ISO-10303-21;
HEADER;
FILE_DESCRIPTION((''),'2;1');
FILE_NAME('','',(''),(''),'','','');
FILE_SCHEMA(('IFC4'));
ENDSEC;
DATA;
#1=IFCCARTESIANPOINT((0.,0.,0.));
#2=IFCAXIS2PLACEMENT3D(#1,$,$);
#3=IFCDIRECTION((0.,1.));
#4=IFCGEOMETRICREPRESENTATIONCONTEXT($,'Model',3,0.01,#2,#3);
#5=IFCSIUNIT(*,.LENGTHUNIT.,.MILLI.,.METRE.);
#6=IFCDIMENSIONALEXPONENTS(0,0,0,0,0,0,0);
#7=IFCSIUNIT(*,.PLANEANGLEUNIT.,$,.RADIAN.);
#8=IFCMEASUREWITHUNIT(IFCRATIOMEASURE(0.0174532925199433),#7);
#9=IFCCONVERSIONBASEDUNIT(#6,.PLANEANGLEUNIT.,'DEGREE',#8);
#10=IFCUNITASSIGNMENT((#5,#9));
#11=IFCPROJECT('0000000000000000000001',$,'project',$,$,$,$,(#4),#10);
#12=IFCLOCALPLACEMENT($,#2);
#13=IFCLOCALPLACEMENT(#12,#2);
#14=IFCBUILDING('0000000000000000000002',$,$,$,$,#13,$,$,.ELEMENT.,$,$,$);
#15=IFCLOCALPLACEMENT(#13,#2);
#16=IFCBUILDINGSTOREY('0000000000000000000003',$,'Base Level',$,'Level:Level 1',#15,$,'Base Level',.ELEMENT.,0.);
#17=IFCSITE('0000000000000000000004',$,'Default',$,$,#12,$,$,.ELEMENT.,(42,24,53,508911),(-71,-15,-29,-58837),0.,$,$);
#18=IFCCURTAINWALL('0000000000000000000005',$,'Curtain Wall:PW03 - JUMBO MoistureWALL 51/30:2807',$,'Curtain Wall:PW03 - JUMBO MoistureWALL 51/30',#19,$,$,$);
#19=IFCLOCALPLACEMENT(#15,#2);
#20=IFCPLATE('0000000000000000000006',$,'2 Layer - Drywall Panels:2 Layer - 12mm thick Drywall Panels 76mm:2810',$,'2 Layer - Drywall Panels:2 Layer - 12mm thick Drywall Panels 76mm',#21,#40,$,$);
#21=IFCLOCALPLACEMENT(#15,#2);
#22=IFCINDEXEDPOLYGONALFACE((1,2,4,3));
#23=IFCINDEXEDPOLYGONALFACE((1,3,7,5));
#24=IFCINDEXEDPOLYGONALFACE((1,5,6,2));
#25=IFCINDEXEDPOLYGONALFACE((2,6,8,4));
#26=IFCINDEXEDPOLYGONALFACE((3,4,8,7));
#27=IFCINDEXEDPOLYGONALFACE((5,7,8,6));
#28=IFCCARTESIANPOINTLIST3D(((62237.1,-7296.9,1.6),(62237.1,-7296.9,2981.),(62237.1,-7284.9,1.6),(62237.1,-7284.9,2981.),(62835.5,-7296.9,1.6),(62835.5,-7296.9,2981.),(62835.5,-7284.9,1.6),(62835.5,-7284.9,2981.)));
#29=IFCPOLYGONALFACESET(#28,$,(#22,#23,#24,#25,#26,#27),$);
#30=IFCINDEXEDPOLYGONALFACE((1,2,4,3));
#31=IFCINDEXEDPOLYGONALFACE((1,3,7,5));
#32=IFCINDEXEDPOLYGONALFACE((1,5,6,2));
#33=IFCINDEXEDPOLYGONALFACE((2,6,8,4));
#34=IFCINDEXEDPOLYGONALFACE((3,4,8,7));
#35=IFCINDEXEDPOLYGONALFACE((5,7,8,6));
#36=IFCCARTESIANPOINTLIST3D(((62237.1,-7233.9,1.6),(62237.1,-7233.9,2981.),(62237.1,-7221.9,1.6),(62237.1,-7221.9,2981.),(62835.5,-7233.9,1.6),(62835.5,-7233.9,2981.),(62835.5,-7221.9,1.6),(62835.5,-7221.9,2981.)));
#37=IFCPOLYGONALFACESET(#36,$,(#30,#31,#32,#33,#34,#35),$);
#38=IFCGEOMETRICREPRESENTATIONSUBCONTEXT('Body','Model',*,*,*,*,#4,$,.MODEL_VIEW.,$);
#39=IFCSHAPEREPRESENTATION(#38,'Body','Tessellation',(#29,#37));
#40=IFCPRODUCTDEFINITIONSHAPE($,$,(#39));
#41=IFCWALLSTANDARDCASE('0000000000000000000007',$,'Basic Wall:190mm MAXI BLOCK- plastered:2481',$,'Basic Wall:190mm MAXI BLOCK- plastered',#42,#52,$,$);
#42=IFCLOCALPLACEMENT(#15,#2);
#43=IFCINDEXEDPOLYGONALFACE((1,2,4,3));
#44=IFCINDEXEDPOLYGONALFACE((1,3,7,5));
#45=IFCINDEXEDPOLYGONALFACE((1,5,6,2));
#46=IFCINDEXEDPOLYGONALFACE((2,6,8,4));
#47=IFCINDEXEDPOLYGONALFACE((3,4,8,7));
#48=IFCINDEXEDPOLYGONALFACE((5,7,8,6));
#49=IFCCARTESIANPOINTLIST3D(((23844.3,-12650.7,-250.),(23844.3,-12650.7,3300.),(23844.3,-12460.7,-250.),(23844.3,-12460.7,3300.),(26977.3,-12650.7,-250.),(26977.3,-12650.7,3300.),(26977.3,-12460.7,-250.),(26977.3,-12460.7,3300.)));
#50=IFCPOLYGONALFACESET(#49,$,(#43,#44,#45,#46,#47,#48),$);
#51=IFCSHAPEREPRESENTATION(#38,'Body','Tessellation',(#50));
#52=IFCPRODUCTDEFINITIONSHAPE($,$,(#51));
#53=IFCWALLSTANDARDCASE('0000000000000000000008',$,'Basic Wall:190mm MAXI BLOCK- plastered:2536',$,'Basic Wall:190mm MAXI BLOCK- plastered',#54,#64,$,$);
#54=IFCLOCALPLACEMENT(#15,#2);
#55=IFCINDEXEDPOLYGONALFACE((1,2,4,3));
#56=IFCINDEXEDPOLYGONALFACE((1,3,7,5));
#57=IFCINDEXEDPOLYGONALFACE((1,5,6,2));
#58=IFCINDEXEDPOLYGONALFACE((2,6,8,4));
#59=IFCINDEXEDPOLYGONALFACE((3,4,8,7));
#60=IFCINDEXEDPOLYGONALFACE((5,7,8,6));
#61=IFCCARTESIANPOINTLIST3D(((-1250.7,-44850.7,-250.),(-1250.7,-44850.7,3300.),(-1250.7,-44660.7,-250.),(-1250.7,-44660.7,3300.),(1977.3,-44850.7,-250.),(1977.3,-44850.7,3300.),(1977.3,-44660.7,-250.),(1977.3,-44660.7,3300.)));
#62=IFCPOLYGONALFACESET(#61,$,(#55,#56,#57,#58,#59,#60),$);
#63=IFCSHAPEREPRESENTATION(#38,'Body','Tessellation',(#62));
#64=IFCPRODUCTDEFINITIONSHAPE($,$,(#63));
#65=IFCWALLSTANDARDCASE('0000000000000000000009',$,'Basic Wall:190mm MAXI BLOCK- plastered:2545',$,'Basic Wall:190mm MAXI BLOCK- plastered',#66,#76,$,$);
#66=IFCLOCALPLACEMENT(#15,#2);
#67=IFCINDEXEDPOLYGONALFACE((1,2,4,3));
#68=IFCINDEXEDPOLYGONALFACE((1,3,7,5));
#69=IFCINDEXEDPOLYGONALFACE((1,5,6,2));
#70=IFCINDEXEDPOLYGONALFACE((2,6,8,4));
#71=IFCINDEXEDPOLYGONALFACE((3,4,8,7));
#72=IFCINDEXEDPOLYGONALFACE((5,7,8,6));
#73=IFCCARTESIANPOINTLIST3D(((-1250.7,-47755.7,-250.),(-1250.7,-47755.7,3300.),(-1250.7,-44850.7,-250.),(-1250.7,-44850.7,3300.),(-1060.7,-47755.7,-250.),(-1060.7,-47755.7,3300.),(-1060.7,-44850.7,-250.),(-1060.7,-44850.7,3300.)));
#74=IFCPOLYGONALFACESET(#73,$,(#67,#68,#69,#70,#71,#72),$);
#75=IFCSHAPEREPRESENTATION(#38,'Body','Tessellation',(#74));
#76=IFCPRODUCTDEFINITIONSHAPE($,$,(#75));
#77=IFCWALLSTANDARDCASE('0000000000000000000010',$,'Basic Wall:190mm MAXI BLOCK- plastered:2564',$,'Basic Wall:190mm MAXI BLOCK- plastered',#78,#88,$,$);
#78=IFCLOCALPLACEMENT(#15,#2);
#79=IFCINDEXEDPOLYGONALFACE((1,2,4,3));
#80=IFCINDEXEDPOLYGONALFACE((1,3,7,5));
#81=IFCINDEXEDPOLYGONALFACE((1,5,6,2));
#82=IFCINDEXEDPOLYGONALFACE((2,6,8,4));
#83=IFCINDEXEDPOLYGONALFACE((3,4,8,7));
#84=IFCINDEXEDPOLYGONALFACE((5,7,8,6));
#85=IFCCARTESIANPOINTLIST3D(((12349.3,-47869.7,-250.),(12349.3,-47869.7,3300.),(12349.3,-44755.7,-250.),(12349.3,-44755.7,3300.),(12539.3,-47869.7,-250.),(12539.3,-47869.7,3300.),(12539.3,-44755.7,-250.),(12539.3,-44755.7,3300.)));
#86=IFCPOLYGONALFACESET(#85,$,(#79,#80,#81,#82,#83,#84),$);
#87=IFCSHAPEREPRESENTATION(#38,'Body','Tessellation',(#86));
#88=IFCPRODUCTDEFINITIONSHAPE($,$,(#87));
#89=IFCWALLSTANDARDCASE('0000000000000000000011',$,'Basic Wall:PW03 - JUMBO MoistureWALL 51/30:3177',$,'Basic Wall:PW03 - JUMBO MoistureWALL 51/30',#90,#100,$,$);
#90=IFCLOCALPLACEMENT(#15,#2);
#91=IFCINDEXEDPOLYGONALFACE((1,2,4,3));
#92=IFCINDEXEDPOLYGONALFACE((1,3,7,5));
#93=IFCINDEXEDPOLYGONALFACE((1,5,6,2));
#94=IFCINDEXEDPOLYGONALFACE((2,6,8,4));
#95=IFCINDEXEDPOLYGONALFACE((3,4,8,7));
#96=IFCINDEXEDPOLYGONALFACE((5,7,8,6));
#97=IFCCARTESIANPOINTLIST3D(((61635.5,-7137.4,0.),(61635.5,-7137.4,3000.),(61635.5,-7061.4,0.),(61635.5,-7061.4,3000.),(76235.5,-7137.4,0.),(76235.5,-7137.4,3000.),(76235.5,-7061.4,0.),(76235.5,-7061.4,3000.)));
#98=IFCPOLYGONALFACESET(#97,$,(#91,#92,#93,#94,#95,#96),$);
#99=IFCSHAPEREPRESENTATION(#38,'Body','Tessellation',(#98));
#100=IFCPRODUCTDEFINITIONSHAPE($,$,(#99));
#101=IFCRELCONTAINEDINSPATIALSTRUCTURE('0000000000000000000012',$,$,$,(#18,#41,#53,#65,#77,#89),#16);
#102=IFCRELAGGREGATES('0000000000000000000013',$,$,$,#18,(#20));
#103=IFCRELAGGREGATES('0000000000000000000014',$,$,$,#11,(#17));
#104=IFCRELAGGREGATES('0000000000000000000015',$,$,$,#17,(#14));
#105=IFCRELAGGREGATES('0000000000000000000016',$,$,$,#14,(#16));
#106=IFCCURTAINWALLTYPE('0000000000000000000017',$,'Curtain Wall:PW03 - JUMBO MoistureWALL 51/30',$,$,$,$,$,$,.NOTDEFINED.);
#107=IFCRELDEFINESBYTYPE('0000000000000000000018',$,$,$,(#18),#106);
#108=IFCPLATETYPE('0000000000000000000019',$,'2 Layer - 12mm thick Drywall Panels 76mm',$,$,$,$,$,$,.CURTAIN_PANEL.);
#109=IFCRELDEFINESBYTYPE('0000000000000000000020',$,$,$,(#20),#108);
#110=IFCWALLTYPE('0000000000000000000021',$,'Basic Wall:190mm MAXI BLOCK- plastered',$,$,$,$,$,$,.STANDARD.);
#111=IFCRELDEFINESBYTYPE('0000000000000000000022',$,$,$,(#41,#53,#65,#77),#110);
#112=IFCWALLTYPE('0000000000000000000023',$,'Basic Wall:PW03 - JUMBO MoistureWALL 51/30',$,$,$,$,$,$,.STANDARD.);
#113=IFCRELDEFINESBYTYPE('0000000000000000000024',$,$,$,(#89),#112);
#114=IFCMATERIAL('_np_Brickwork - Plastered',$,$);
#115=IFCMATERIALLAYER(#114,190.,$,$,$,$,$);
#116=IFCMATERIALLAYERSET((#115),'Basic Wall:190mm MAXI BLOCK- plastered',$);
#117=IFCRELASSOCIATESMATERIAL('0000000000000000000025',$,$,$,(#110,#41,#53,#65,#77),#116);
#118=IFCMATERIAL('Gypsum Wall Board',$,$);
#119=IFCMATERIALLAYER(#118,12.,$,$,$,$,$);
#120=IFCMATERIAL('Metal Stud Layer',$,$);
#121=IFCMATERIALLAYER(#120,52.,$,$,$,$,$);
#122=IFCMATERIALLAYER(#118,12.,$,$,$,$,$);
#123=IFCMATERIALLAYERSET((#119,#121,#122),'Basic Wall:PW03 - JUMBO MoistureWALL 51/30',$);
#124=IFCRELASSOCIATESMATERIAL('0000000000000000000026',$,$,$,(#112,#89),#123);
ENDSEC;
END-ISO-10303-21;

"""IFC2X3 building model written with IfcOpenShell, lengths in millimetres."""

from ifc_helpers import new_model, entity, si_unit, converted_unit, direction, frame, frame_2d, origin, origin_2d_with_axis, place, context, subcontext, project, spatial, rectangle, extrude, source, transform, mapped, material, layer, layer_set, layer_usage, type_object, type_shapes, element, aggregate, save


model = new_model("IFC2X3")

# Units and contexts
model_context = context("Model", 3, precision=0.01, world=origin(), true_north=direction((0.0, 1.0)))
body_context = subcontext(model_context, "Body", "Model", "MODEL_VIEW")
ifc_project = project(units=[si_unit("LENGTHUNIT", "METRE", prefix="MILLI"), converted_unit("PLANEANGLEUNIT", "DEGREE", entity("IfcRatioMeasure", 0.0174532925199433), si_unit("PLANEANGLEUNIT", "RADIAN"), dimensions=[0, 0, 0, 0, 0, 0, 0])], contexts=[model_context])

# Site, building, storey
site_placement = place(None, origin())
site = spatial("IfcSite", under=ifc_project, at=site_placement, Name="Default", CompositionType="ELEMENT", RefLatitude=(42, 24, 53, 508911), RefLongitude=(-71, -15, -29, -58837), RefElevation=0.0)
building_placement = place(site_placement, origin())
building = spatial("IfcBuilding", under=site, at=building_placement, CompositionType="ELEMENT")
storey_placement = place(building_placement, origin())
storey = spatial("IfcBuildingStorey", under=building, at=storey_placement, Name="Base Level", ObjectType="Level:Level 1", LongName="Base Level", CompositionType="ELEMENT", Elevation=0.0)

# Curtain wall
curtain_wall_type_1 = type_object("IfcCurtainWallType", Name="Curtain Wall:PW03 - JUMBO MoistureWALL 51/30", PredefinedType="NOTDEFINED")
curtain_wall_1_placement = place(building_placement, origin())
curtain_wall_1 = element("IfcCurtainWall", 1, at=curtain_wall_1_placement, inside=storey, type_object=curtain_wall_type_1, Name="Curtain Wall:PW03 - JUMBO MoistureWALL 51/30:2807", ObjectType="Curtain Wall:PW03 - JUMBO MoistureWALL 51/30")

# Plate
plate_type = type_object("IfcPlateType", Name="2 Layer - 12mm thick Drywall Panels 76mm", PredefinedType="CURTAIN_PANEL")
shared_shape_1 = source(origin(), body_context, "Body", "SweptSolid", [
    extrude(rectangle(XDim=598.4, YDim=12.0, at=origin_2d_with_axis()), frame((0.0, -31.5, 0.0), z_axis=(0.0, 0.0, 1.0), x_axis=(-1.0, 0.0, 0.0)), (0.0, 0.0, 1.0), 2979.4),
    extrude(rectangle(XDim=12.0, YDim=598.4, at=frame_2d((0.0, 0.0), x_axis=(1.0, 0.0))), frame((0.0, 31.5, 0.0), z_axis=(0.0, 0.0, 1.0), x_axis=(0.0, 1.0, 0.0)), (0.0, 0.0, 1.0), 2979.4),
])
type_shapes(plate_type, [shared_shape_1])
plate_1_placement = place(curtain_wall_1_placement, frame((62536.3, -7259.4, 1.6)))
plate_1 = element("IfcPlate", 2, at=plate_1_placement, type_object=plate_type, Name="2 Layer - Drywall Panels:2 Layer - 12mm thick Drywall Panels 76mm:2810", ObjectType="2 Layer - Drywall Panels:2 Layer - 12mm thick Drywall Panels 76mm", context=body_context, shape_type="MappedRepresentation", body=[
    mapped(shared_shape_1, transform((0.0, 0.0, 0.0), scale=1.0)),
])
aggregate(curtain_wall_1, [plate_1])

# Walls
ifc_material_1 = material(Name="_np_Brickwork - Plastered")
ifc_layer_1 = layer(ifc_material_1, 190.0)
ifc_layer_set_1 = layer_set([ifc_layer_1], Name="Basic Wall:190mm MAXI BLOCK- plastered")
ifc_layer_usage_1 = layer_usage(ifc_layer_set_1, "AXIS2", "NEGATIVE", 95.0)
wall_type_1 = type_object("IfcWallType", Name="Basic Wall:190mm MAXI BLOCK- plastered", PredefinedType="STANDARD", material=ifc_layer_set_1)
wall_1_placement = place(building_placement, frame((23844.3, -12555.7, -250.0)))
element("IfcWallStandardCase", 3, at=wall_1_placement, inside=storey, type_object=wall_type_1, material=ifc_layer_usage_1, Name="Basic Wall:190mm MAXI BLOCK- plastered:2481", ObjectType="Basic Wall:190mm MAXI BLOCK- plastered", context=body_context, shape_type="SweptSolid", body=[
    extrude(rectangle(XDim=3133.0, YDim=190.0, at=frame_2d((1566.5, 0.0), x_axis=(-1.0, 0.0))), origin(), (0.0, 0.0, 1.0), 3550.0),
])
ifc_layer_usage_2 = layer_usage(ifc_layer_set_1, "AXIS2", "NEGATIVE", 95.0)
wall_2_placement = place(building_placement, frame((-1250.7, -44755.7, -250.0)))
element("IfcWallStandardCase", 4, at=wall_2_placement, inside=storey, type_object=wall_type_1, material=ifc_layer_usage_2, Name="Basic Wall:190mm MAXI BLOCK- plastered:2536", ObjectType="Basic Wall:190mm MAXI BLOCK- plastered", context=body_context, shape_type="SweptSolid", body=[
    extrude(rectangle(XDim=3228.0, YDim=190.0, at=frame_2d((1614.0, 0.0), x_axis=(-1.0, 0.0))), origin(), (0.0, 0.0, 1.0), 3550.0),
])
ifc_layer_usage_3 = layer_usage(ifc_layer_set_1, "AXIS2", "NEGATIVE", 95.0)
wall_3_placement = place(building_placement, frame((-1155.7, -47755.7, -250.0), z_axis=(0.0, 0.0, 1.0), x_axis=(0.0, 1.0, 0.0)))
element("IfcWallStandardCase", 5, at=wall_3_placement, inside=storey, type_object=wall_type_1, material=ifc_layer_usage_3, Name="Basic Wall:190mm MAXI BLOCK- plastered:2545", ObjectType="Basic Wall:190mm MAXI BLOCK- plastered", context=body_context, shape_type="SweptSolid", body=[
    extrude(rectangle(XDim=2905.0, YDim=190.0, at=frame_2d((1452.5, 0.0), x_axis=(-1.0, 0.0))), origin(), (0.0, 0.0, 1.0), 3550.0),
])
ifc_layer_usage_4 = layer_usage(ifc_layer_set_1, "AXIS2", "NEGATIVE", 95.0)
wall_4_placement = place(building_placement, frame((12444.3, -47869.7, -250.0), z_axis=(0.0, 0.0, 1.0), x_axis=(0.0, 1.0, 0.0)))
element("IfcWallStandardCase", 6, at=wall_4_placement, inside=storey, type_object=wall_type_1, material=ifc_layer_usage_4, Name="Basic Wall:190mm MAXI BLOCK- plastered:2564", ObjectType="Basic Wall:190mm MAXI BLOCK- plastered", context=body_context, shape_type="SweptSolid", body=[
    extrude(rectangle(XDim=3114.0, YDim=190.0, at=frame_2d((1557.0, 0.0), x_axis=(-1.0, 0.0))), origin(), (0.0, 0.0, 1.0), 3550.0),
])
ifc_material_2 = material(Name="Gypsum Wall Board")
ifc_layer_2 = layer(ifc_material_2, 12.0)
ifc_material_3 = material(Name="Metal Stud Layer")
ifc_layer_3 = layer(ifc_material_3, 52.0)
ifc_layer_4 = layer(ifc_material_2, 12.0)
ifc_layer_set_2 = layer_set([ifc_layer_2, ifc_layer_3, ifc_layer_4], Name="Basic Wall:PW03 - JUMBO MoistureWALL 51/30")
ifc_layer_usage_5 = layer_usage(ifc_layer_set_2, "AXIS2", "NEGATIVE", 38.0)
wall_type_2 = type_object("IfcWallType", Name="Basic Wall:PW03 - JUMBO MoistureWALL 51/30", PredefinedType="STANDARD", material=ifc_layer_set_2)
wall_5_placement = place(building_placement, frame((61635.5, -7099.4, 0.0)))
element("IfcWallStandardCase", 7, at=wall_5_placement, inside=storey, type_object=wall_type_2, material=ifc_layer_usage_5, Name="Basic Wall:PW03 - JUMBO MoistureWALL 51/30:3177", ObjectType="Basic Wall:PW03 - JUMBO MoistureWALL 51/30", context=body_context, shape_type="SweptSolid", body=[
    extrude(rectangle(XDim=14600.0, YDim=76.0, at=frame_2d((7300.0, 0.0), x_axis=(-1.0, 0.0))), origin(), (0.0, 0.0, 1.0), 3000.0),
])

save(model, "model.ifc")
